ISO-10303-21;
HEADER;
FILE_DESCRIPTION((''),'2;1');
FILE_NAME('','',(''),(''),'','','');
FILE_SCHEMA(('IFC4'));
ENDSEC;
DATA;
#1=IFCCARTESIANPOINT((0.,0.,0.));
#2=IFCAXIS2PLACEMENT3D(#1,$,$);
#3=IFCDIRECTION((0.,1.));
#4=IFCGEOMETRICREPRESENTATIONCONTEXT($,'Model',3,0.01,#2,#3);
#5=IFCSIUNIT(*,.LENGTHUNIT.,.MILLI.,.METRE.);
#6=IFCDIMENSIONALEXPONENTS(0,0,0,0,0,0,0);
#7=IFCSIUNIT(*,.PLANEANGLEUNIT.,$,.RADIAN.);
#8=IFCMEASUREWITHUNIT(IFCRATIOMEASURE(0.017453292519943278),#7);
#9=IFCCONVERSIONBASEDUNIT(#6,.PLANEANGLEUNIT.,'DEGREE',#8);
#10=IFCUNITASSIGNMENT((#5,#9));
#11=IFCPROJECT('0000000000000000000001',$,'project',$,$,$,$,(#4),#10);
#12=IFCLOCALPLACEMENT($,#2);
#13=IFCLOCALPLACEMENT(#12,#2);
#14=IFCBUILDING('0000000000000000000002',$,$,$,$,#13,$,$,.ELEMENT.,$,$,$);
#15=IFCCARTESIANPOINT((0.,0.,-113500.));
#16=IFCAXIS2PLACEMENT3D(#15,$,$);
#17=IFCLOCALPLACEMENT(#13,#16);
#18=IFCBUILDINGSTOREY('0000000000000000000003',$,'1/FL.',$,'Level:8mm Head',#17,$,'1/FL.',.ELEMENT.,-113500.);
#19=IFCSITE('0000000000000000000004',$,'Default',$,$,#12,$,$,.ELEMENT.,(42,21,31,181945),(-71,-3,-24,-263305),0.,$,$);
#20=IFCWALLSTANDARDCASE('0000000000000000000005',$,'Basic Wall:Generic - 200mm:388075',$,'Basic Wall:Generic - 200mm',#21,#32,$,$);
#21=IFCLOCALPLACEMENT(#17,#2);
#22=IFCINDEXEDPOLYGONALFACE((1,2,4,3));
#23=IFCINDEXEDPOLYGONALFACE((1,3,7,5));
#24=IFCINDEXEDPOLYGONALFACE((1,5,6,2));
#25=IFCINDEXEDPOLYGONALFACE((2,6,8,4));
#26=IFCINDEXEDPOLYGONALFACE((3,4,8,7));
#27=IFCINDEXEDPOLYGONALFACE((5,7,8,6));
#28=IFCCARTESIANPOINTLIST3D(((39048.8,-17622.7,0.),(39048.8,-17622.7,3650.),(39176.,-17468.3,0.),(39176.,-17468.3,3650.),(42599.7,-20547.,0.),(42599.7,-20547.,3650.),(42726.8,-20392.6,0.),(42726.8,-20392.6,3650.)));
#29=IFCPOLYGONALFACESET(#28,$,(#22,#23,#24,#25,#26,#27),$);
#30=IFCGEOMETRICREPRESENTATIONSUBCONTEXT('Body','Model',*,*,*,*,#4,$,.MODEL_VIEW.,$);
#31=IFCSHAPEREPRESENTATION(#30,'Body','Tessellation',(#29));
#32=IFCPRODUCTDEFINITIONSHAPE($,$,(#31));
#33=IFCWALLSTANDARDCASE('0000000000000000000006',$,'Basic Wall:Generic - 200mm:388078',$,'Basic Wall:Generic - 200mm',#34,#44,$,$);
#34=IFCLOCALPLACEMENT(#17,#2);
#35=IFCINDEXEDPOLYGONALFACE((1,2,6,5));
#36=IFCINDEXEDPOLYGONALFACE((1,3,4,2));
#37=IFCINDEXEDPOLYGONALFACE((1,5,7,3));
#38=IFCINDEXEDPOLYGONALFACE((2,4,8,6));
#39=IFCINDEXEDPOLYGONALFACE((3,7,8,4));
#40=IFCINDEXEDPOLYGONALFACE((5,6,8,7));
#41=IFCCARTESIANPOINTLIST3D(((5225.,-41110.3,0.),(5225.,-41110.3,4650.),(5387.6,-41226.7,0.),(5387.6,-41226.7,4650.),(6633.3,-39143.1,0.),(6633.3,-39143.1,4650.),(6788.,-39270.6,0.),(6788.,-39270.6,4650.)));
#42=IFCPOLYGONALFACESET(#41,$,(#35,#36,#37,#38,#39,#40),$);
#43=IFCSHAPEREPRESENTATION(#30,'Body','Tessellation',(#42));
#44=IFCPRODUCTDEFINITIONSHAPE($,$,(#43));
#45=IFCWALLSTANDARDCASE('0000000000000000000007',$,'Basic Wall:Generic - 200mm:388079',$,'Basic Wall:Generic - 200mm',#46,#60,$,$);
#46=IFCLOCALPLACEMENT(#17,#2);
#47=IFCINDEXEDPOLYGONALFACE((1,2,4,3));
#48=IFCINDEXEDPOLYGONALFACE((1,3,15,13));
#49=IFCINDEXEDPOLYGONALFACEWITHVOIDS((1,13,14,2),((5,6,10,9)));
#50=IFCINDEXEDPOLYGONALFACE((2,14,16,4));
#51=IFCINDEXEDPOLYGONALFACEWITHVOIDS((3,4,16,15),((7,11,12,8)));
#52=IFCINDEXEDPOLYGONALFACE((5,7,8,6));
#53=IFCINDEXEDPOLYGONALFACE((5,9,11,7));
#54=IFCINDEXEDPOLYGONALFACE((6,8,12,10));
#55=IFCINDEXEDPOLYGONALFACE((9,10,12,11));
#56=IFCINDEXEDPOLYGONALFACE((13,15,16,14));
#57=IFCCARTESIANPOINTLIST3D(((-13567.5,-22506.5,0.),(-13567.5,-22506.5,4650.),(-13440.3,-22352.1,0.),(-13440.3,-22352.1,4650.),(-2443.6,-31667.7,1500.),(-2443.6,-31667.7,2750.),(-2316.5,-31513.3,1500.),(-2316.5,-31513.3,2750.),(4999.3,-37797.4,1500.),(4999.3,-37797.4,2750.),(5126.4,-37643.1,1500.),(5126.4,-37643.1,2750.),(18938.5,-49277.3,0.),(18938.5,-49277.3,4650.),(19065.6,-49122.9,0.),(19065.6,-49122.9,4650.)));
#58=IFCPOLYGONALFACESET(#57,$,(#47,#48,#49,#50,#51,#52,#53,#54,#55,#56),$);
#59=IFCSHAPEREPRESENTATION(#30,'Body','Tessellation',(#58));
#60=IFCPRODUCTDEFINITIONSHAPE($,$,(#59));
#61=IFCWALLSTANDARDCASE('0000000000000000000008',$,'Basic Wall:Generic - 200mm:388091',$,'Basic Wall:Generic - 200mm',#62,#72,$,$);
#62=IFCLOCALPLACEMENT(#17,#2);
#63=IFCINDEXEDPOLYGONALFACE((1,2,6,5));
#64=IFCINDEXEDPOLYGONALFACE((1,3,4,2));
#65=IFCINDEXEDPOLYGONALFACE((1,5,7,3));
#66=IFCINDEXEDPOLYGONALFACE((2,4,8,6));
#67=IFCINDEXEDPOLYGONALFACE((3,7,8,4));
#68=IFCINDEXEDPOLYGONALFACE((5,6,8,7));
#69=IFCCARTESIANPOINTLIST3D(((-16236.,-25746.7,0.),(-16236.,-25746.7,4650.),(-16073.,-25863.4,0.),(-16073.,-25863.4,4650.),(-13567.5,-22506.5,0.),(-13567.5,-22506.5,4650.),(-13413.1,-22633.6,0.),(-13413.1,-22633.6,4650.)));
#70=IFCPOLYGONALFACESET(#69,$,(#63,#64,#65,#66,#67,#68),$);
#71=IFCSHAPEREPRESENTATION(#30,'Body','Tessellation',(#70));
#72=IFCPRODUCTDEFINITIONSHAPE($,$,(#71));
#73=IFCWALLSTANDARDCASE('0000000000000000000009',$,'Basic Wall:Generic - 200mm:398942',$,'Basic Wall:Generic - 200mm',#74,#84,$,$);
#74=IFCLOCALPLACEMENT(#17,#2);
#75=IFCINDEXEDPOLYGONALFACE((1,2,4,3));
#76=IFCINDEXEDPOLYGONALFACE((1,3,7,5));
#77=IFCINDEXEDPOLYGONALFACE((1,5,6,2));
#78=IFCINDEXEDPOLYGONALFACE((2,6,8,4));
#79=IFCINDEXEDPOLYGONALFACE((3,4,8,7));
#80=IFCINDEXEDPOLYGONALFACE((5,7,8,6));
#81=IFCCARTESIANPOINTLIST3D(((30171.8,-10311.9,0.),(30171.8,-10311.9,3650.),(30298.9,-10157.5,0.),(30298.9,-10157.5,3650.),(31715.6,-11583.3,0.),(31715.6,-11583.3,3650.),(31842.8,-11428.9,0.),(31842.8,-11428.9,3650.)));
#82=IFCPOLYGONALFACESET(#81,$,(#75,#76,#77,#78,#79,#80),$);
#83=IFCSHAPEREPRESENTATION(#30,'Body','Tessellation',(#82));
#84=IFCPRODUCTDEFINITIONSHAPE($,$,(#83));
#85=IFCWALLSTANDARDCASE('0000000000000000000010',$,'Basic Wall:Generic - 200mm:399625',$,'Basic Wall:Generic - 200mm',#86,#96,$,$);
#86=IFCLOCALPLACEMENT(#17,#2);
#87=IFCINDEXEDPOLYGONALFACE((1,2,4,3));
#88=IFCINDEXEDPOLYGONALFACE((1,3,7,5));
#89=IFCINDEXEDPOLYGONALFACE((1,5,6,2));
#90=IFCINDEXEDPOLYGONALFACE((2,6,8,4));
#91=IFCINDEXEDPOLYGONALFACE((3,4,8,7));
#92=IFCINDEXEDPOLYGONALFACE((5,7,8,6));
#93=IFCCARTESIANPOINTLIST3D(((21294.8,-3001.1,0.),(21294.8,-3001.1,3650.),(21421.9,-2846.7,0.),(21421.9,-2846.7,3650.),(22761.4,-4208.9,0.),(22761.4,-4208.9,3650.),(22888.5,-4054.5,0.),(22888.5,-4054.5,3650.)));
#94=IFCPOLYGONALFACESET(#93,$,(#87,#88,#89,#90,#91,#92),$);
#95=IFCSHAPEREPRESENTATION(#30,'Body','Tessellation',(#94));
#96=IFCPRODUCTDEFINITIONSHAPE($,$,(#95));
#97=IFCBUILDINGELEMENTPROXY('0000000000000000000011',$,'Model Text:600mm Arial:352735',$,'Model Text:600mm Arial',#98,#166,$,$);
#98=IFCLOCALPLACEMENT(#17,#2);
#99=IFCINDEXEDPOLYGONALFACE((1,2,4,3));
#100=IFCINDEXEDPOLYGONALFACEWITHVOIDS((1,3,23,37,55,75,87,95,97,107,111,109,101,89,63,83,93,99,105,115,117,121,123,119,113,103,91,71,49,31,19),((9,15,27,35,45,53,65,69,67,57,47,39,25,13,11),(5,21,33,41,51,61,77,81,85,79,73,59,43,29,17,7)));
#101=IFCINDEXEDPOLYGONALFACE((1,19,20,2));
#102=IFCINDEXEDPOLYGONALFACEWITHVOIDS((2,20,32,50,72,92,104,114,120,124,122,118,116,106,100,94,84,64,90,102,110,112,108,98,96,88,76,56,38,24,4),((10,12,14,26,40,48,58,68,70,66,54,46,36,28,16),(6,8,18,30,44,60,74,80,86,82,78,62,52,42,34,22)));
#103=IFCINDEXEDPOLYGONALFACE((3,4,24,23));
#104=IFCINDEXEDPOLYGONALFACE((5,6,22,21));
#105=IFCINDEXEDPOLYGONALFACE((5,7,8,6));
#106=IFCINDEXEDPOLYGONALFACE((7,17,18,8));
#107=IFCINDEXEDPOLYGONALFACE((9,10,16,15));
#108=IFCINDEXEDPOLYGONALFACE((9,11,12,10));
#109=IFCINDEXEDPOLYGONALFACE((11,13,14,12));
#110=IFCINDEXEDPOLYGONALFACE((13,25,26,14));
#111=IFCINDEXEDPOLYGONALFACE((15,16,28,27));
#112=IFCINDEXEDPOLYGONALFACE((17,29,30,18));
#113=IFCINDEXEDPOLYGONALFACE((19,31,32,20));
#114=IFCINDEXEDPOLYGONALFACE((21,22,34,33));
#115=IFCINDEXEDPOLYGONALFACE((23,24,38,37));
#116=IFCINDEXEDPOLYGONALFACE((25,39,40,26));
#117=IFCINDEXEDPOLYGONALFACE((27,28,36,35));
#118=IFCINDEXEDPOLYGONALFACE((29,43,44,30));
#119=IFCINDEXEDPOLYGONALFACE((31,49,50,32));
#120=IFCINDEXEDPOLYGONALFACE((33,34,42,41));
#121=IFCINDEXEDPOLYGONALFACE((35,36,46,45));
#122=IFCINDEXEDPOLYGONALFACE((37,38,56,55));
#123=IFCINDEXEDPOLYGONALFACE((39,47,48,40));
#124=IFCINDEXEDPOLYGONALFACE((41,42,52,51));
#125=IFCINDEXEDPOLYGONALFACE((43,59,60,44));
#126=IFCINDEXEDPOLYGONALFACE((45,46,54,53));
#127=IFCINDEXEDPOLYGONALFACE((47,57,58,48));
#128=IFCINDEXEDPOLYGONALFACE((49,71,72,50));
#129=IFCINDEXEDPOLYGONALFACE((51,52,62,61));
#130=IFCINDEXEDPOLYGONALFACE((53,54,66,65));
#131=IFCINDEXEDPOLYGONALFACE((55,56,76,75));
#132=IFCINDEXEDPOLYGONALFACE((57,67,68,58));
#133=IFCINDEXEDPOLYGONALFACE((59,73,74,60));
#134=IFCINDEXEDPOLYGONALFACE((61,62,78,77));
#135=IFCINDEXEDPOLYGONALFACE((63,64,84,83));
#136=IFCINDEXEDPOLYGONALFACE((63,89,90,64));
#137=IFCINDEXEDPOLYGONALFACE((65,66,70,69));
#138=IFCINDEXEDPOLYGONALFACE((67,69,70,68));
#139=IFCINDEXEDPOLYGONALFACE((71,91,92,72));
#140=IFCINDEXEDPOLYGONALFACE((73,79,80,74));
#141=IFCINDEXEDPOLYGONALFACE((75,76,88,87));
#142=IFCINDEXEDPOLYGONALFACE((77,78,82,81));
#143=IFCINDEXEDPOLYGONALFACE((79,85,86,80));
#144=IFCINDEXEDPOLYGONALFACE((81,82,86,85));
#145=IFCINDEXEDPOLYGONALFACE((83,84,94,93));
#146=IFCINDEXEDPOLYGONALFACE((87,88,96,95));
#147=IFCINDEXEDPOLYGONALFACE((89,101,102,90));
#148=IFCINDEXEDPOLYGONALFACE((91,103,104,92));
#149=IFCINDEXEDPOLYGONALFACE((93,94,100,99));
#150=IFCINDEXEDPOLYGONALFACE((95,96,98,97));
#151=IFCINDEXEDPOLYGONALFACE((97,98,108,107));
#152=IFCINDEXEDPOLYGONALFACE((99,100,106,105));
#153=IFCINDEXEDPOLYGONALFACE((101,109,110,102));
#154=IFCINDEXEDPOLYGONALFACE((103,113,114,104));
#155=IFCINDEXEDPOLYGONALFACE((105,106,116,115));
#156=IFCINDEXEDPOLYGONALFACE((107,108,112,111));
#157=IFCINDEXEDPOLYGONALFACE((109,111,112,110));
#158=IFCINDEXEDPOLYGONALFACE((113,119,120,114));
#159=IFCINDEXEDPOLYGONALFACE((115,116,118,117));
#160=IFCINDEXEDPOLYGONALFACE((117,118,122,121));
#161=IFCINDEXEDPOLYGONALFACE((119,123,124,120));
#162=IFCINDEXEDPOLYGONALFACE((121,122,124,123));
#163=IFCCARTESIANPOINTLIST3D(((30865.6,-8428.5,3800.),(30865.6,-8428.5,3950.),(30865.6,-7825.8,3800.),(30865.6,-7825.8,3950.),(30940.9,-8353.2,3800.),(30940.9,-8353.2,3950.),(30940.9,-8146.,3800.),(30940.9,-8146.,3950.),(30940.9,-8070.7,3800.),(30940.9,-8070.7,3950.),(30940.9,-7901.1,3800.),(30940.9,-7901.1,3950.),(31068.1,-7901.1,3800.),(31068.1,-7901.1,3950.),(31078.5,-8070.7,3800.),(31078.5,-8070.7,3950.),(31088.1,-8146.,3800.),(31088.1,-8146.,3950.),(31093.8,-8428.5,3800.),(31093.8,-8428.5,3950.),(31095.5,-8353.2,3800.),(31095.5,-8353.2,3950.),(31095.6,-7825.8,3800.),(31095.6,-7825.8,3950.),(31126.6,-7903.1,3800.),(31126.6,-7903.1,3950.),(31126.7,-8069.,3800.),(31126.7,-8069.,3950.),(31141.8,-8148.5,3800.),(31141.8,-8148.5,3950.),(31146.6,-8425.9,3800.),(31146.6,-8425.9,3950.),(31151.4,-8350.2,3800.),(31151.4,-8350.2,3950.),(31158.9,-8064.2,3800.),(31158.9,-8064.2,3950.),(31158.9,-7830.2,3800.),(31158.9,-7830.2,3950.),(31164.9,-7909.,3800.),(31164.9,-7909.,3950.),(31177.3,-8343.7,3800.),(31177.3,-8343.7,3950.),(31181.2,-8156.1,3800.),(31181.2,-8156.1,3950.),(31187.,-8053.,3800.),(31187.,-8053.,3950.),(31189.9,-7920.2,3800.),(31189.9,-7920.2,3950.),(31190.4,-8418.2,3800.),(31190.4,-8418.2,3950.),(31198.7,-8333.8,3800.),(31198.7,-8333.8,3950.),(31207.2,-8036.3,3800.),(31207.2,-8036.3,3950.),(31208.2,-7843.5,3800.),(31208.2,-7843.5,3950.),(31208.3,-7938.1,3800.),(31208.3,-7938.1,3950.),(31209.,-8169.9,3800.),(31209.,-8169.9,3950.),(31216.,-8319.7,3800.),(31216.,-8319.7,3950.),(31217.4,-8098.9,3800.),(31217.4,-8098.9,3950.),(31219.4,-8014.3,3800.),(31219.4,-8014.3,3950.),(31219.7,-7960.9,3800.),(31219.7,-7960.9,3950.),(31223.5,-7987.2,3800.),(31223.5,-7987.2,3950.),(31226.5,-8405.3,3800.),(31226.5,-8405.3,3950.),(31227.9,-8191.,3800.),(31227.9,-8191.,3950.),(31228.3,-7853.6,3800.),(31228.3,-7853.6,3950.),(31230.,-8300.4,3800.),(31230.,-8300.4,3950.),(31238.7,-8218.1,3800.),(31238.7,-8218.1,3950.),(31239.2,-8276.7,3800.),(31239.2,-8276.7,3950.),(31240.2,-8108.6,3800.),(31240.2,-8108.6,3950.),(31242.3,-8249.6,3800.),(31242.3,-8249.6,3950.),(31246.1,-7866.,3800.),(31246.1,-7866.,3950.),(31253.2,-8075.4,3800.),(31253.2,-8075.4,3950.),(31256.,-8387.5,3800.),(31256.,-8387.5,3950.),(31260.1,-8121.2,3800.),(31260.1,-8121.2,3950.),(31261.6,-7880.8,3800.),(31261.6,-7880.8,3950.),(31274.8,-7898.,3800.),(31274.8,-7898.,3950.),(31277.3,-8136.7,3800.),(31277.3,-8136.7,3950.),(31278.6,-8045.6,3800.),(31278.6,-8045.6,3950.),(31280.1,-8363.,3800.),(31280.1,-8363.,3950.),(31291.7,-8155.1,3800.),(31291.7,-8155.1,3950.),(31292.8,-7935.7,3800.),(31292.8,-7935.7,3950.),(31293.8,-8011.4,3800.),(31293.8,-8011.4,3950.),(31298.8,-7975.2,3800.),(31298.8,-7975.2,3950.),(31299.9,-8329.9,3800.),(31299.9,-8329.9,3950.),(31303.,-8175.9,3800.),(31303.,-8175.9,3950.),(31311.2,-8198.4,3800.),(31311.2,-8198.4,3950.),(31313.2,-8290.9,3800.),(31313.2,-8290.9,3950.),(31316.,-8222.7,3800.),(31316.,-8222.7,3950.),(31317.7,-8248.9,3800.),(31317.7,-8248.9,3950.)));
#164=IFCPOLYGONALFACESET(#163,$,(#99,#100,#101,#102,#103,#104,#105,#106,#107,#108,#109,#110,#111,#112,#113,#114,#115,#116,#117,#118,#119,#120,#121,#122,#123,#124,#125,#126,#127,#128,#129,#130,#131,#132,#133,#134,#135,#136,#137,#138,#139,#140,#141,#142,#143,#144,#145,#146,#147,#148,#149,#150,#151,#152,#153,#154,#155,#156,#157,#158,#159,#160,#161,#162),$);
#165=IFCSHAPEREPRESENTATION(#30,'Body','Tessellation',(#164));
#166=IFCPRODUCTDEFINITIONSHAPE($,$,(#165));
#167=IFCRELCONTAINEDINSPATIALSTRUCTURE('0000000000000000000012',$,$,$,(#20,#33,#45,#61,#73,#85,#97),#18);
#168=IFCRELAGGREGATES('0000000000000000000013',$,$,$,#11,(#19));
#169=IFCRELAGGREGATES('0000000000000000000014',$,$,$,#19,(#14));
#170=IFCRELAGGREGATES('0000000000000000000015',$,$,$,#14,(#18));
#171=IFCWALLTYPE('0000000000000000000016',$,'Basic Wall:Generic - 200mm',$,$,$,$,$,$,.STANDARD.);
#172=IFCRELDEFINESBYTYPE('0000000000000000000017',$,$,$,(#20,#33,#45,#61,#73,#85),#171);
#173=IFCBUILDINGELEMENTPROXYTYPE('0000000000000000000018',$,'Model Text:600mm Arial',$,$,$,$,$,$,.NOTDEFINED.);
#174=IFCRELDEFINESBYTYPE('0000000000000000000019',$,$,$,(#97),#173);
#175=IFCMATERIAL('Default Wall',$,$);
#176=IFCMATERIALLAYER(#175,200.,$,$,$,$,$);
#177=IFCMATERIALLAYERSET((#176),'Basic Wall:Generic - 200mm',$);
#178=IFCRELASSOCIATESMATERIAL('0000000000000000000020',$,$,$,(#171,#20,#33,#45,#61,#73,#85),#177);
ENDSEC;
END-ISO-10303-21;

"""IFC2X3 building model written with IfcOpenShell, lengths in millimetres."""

from ifc_helpers import new_model, entity, si_unit, converted_unit, direction, frame, frame_2d, origin, origin_2d_with_axis, place, context, subcontext, project, spatial, polyline, rectangle, outline, extrude, material, layer, layer_set, layer_usage, type_object, element, save


model = new_model("IFC2X3")

# Units and contexts
model_context = context("Model", 3, precision=0.01, world=origin(), true_north=direction((0.0, 1.0)))
body_context = subcontext(model_context, "Body", "Model", "MODEL_VIEW")
ifc_project = project(units=[si_unit("LENGTHUNIT", "METRE", prefix="MILLI"), converted_unit("PLANEANGLEUNIT", "DEGREE", entity("IfcRatioMeasure", 0.017453292519943278), si_unit("PLANEANGLEUNIT", "RADIAN"), dimensions=[0, 0, 0, 0, 0, 0, 0])], contexts=[model_context])

# Site, building, storey
site_placement = place(None, origin())
site = spatial("IfcSite", under=ifc_project, at=site_placement, Name="Default", CompositionType="ELEMENT", RefLatitude=(42, 21, 31, 181945), RefLongitude=(-71, -3, -24, -263305), RefElevation=0.0)
building_placement = place(site_placement, origin())
building = spatial("IfcBuilding", under=site, at=building_placement, CompositionType="ELEMENT")
storey_placement = place(building_placement, frame((0.0, 0.0, -113500.0)))
storey = spatial("IfcBuildingStorey", under=building, at=storey_placement, Name="1/FL.", ObjectType="Level:8mm Head", LongName="1/FL.", CompositionType="ELEMENT", Elevation=-113500.0)

# Shared definitions
ifc_material_1 = material(Name="Default Wall")
ifc_layer_1 = layer(ifc_material_1, 200.0)
ifc_layer_set_1 = layer_set([ifc_layer_1], Name="Basic Wall:Generic - 200mm")
ifc_layer_usage_1 = layer_usage(ifc_layer_set_1, "AXIS2", "NEGATIVE", 100.0)
wall_type = type_object("IfcWallType", Name="Basic Wall:Generic - 200mm", PredefinedType="STANDARD", material=ifc_layer_set_1)

# Wall
wall_1_placement = place(storey_placement, frame((42663.2, -20469.8, 0.0), z_axis=(0.0, 0.0, 1.0), x_axis=(-0.771917, 0.635723, 0.0)))
element("IfcWallStandardCase", 1, at=wall_1_placement, inside=storey, type_object=wall_type, material=ifc_layer_usage_1, Name="Basic Wall:Generic - 200mm:388075", ObjectType="Basic Wall:Generic - 200mm", context=body_context, shape_type="SweptSolid", body=[
    extrude(rectangle(XDim=4600.0, YDim=200.0, at=frame_2d((2300.0, 0.0), x_axis=(-1.0, 0.0))), origin(), (0.0, 0.0, 1.0), 3650.0),
])

# Wall
wall_2_placement = place(storey_placement, frame((5306.3, -41168.5, 0.0), z_axis=(0.0, 0.0, 1.0), x_axis=(0.582098, 0.813119, 0.0)))
element("IfcWallStandardCase", 2, at=wall_2_placement, inside=storey, type_object=wall_type, material=ifc_layer_usage_1, Name="Basic Wall:Generic - 200mm:388078", ObjectType="Basic Wall:Generic - 200mm", context=body_context, shape_type="SweptSolid", body=[
    extrude(outline(polyline([(2405.7, -100.0), (2419.3, 100.0), (0.0, 100.0), (0.0, -100.0), (2405.7, -100.0)])), origin(), (0.0, 0.0, 1.0), 4650.0),
])

# Wall, opening
wall_3_placement = place(storey_placement, frame((-13503.9, -22429.3, 0.0), z_axis=(0.0, 0.0, 1.0), x_axis=(0.771917, -0.635723, 0.0)))
wall_3 = element("IfcWallStandardCase", 3, at=wall_3_placement, inside=storey, type_object=wall_type, material=ifc_layer_usage_1, Name="Basic Wall:Generic - 200mm:388079", ObjectType="Basic Wall:Generic - 200mm", context=body_context, shape_type="SweptSolid", body=[
    extrude(rectangle(XDim=42110.7, YDim=200.0, at=frame_2d((21055.3, 0.0), x_axis=(-1.0, 0.0))), origin(), (0.0, 0.0, 1.0), 4650.0),
])
opening_1_placement = place(wall_3_placement, origin())
element("IfcOpeningElement", 4, at=opening_1_placement, cuts=wall_3, ObjectType="Opening", context=body_context, shape_type="SweptSolid", body=[
    extrude(rectangle(XDim=1250.0, YDim=9642.1, at=origin_2d_with_axis()), frame((19231.8, -100.0, 2125.0), z_axis=(0.0, 1.0, 0.0), x_axis=(0.0, 0.0, -1.0)), (0.0, 0.0, 1.0), 200.0),
])

# Walls
wall_4_placement = place(storey_placement, frame((-16158.8, -25810.3, 0.0), z_axis=(0.0, 0.0, 1.0), x_axis=(0.635723, 0.771917, 0.0)))
element("IfcWallStandardCase", 5, at=wall_4_placement, inside=storey, type_object=wall_type, material=ifc_layer_usage_1, Name="Basic Wall:Generic - 200mm:388091", ObjectType="Basic Wall:Generic - 200mm", context=body_context, shape_type="SweptSolid", body=[
    extrude(outline(polyline([(4197.6, -100.0), (4197.6, 100.0), (0.0, 100.0), (13.5, -100.0), (4197.6, -100.0)])), origin(), (0.0, 0.0, 1.0), 4650.0),
])
wall_5_placement = place(storey_placement, frame((31779.2, -11506.1, 0.0), z_axis=(0.0, 0.0, 1.0), x_axis=(-0.771917, 0.635723, 0.0)))
element("IfcWallStandardCase", 6, at=wall_5_placement, inside=storey, type_object=wall_type, material=ifc_layer_usage_1, Name="Basic Wall:Generic - 200mm:398942", ObjectType="Basic Wall:Generic - 200mm", context=body_context, shape_type="SweptSolid", body=[
    extrude(rectangle(XDim=2000.0, YDim=200.0, at=frame_2d((1000.0, 0.0), x_axis=(-1.0, 0.0))), origin(), (0.0, 0.0, 1.0), 3650.0),
])
wall_6_placement = place(storey_placement, frame((22825.0, -4131.7, 0.0), z_axis=(0.0, 0.0, 1.0), x_axis=(-0.771917, 0.635723, 0.0)))
element("IfcWallStandardCase", 7, at=wall_6_placement, inside=storey, type_object=wall_type, material=ifc_layer_usage_1, Name="Basic Wall:Generic - 200mm:399625", ObjectType="Basic Wall:Generic - 200mm", context=body_context, shape_type="SweptSolid", body=[
    extrude(rectangle(XDim=1900.0, YDim=200.0, at=frame_2d((950.0, 0.0), x_axis=(-1.0, 0.0))), origin(), (0.0, 0.0, 1.0), 3650.0),
])

# Building element proxy
building_element_proxy_type = type_object("IfcBuildingElementProxyType", Name="Model Text:600mm Arial", PredefinedType="NOTDEFINED")
proxy_1_placement = place(storey_placement, origin())
element("IfcBuildingElementProxy", 8, at=proxy_1_placement, inside=storey, type_object=building_element_proxy_type, Name="Model Text:600mm Arial:352735", ObjectType="Model Text:600mm Arial", context=body_context, shape_type="SweptSolid", body=[
    extrude(outline(polyline([(-359.0, -305.6), (-130.8, -305.6), (-78.0, -303.0), (-34.2, -295.2), (1.9, -282.4), (31.4, -264.6), (55.5, -240.1), (75.3, -206.9), (88.6, -167.9), (93.0, -125.9), (91.4, -99.8), (86.5, -75.5), (78.4, -52.9), (67.1, -32.2), (52.7, -13.8), (35.5, 1.7), (15.6, 14.3), (-7.2, 24.0), (28.6, 47.5), (54.0, 77.4), (69.1, 111.5), (74.2, 147.8), (68.2, 187.2), (50.1, 224.9), (37.0, 242.1), (21.5, 256.9), (3.7, 269.4), (-16.4, 279.4), (-65.8, 292.7), (-129.0, 297.2), (-359.0, 297.2), (-359.0, -305.6)]), holes=[polyline([(-283.7, 52.3), (-283.7, 221.8), (-156.5, 221.8), (-98.0, 219.8), (-59.7, 213.9), (-34.7, 202.7), (-16.3, 184.9), (-4.9, 162.0), (-1.1, 135.7), (-5.2, 108.7), (-17.4, 86.7), (-37.6, 69.9), (-65.7, 58.8), (-98.0, 53.9), (-146.1, 52.3), (-283.7, 52.3)]), polyline([(-283.7, -230.2), (-283.7, -23.1), (-136.5, -23.1), (-82.9, -25.6), (-43.4, -33.1), (-15.6, -46.9), (3.3, -68.1), (14.1, -95.2), (17.7, -126.6), (14.6, -153.8), (5.4, -177.4), (-8.6, -196.7), (-25.9, -210.9), (-47.3, -220.8), (-73.2, -227.3), (-129.2, -230.2), (-283.7, -230.2)])]), frame((31224.6, -8122.9, 3800.0)), (0.0, 0.0, 1.0), 150.0),
])

save(model, "model.ifc")
